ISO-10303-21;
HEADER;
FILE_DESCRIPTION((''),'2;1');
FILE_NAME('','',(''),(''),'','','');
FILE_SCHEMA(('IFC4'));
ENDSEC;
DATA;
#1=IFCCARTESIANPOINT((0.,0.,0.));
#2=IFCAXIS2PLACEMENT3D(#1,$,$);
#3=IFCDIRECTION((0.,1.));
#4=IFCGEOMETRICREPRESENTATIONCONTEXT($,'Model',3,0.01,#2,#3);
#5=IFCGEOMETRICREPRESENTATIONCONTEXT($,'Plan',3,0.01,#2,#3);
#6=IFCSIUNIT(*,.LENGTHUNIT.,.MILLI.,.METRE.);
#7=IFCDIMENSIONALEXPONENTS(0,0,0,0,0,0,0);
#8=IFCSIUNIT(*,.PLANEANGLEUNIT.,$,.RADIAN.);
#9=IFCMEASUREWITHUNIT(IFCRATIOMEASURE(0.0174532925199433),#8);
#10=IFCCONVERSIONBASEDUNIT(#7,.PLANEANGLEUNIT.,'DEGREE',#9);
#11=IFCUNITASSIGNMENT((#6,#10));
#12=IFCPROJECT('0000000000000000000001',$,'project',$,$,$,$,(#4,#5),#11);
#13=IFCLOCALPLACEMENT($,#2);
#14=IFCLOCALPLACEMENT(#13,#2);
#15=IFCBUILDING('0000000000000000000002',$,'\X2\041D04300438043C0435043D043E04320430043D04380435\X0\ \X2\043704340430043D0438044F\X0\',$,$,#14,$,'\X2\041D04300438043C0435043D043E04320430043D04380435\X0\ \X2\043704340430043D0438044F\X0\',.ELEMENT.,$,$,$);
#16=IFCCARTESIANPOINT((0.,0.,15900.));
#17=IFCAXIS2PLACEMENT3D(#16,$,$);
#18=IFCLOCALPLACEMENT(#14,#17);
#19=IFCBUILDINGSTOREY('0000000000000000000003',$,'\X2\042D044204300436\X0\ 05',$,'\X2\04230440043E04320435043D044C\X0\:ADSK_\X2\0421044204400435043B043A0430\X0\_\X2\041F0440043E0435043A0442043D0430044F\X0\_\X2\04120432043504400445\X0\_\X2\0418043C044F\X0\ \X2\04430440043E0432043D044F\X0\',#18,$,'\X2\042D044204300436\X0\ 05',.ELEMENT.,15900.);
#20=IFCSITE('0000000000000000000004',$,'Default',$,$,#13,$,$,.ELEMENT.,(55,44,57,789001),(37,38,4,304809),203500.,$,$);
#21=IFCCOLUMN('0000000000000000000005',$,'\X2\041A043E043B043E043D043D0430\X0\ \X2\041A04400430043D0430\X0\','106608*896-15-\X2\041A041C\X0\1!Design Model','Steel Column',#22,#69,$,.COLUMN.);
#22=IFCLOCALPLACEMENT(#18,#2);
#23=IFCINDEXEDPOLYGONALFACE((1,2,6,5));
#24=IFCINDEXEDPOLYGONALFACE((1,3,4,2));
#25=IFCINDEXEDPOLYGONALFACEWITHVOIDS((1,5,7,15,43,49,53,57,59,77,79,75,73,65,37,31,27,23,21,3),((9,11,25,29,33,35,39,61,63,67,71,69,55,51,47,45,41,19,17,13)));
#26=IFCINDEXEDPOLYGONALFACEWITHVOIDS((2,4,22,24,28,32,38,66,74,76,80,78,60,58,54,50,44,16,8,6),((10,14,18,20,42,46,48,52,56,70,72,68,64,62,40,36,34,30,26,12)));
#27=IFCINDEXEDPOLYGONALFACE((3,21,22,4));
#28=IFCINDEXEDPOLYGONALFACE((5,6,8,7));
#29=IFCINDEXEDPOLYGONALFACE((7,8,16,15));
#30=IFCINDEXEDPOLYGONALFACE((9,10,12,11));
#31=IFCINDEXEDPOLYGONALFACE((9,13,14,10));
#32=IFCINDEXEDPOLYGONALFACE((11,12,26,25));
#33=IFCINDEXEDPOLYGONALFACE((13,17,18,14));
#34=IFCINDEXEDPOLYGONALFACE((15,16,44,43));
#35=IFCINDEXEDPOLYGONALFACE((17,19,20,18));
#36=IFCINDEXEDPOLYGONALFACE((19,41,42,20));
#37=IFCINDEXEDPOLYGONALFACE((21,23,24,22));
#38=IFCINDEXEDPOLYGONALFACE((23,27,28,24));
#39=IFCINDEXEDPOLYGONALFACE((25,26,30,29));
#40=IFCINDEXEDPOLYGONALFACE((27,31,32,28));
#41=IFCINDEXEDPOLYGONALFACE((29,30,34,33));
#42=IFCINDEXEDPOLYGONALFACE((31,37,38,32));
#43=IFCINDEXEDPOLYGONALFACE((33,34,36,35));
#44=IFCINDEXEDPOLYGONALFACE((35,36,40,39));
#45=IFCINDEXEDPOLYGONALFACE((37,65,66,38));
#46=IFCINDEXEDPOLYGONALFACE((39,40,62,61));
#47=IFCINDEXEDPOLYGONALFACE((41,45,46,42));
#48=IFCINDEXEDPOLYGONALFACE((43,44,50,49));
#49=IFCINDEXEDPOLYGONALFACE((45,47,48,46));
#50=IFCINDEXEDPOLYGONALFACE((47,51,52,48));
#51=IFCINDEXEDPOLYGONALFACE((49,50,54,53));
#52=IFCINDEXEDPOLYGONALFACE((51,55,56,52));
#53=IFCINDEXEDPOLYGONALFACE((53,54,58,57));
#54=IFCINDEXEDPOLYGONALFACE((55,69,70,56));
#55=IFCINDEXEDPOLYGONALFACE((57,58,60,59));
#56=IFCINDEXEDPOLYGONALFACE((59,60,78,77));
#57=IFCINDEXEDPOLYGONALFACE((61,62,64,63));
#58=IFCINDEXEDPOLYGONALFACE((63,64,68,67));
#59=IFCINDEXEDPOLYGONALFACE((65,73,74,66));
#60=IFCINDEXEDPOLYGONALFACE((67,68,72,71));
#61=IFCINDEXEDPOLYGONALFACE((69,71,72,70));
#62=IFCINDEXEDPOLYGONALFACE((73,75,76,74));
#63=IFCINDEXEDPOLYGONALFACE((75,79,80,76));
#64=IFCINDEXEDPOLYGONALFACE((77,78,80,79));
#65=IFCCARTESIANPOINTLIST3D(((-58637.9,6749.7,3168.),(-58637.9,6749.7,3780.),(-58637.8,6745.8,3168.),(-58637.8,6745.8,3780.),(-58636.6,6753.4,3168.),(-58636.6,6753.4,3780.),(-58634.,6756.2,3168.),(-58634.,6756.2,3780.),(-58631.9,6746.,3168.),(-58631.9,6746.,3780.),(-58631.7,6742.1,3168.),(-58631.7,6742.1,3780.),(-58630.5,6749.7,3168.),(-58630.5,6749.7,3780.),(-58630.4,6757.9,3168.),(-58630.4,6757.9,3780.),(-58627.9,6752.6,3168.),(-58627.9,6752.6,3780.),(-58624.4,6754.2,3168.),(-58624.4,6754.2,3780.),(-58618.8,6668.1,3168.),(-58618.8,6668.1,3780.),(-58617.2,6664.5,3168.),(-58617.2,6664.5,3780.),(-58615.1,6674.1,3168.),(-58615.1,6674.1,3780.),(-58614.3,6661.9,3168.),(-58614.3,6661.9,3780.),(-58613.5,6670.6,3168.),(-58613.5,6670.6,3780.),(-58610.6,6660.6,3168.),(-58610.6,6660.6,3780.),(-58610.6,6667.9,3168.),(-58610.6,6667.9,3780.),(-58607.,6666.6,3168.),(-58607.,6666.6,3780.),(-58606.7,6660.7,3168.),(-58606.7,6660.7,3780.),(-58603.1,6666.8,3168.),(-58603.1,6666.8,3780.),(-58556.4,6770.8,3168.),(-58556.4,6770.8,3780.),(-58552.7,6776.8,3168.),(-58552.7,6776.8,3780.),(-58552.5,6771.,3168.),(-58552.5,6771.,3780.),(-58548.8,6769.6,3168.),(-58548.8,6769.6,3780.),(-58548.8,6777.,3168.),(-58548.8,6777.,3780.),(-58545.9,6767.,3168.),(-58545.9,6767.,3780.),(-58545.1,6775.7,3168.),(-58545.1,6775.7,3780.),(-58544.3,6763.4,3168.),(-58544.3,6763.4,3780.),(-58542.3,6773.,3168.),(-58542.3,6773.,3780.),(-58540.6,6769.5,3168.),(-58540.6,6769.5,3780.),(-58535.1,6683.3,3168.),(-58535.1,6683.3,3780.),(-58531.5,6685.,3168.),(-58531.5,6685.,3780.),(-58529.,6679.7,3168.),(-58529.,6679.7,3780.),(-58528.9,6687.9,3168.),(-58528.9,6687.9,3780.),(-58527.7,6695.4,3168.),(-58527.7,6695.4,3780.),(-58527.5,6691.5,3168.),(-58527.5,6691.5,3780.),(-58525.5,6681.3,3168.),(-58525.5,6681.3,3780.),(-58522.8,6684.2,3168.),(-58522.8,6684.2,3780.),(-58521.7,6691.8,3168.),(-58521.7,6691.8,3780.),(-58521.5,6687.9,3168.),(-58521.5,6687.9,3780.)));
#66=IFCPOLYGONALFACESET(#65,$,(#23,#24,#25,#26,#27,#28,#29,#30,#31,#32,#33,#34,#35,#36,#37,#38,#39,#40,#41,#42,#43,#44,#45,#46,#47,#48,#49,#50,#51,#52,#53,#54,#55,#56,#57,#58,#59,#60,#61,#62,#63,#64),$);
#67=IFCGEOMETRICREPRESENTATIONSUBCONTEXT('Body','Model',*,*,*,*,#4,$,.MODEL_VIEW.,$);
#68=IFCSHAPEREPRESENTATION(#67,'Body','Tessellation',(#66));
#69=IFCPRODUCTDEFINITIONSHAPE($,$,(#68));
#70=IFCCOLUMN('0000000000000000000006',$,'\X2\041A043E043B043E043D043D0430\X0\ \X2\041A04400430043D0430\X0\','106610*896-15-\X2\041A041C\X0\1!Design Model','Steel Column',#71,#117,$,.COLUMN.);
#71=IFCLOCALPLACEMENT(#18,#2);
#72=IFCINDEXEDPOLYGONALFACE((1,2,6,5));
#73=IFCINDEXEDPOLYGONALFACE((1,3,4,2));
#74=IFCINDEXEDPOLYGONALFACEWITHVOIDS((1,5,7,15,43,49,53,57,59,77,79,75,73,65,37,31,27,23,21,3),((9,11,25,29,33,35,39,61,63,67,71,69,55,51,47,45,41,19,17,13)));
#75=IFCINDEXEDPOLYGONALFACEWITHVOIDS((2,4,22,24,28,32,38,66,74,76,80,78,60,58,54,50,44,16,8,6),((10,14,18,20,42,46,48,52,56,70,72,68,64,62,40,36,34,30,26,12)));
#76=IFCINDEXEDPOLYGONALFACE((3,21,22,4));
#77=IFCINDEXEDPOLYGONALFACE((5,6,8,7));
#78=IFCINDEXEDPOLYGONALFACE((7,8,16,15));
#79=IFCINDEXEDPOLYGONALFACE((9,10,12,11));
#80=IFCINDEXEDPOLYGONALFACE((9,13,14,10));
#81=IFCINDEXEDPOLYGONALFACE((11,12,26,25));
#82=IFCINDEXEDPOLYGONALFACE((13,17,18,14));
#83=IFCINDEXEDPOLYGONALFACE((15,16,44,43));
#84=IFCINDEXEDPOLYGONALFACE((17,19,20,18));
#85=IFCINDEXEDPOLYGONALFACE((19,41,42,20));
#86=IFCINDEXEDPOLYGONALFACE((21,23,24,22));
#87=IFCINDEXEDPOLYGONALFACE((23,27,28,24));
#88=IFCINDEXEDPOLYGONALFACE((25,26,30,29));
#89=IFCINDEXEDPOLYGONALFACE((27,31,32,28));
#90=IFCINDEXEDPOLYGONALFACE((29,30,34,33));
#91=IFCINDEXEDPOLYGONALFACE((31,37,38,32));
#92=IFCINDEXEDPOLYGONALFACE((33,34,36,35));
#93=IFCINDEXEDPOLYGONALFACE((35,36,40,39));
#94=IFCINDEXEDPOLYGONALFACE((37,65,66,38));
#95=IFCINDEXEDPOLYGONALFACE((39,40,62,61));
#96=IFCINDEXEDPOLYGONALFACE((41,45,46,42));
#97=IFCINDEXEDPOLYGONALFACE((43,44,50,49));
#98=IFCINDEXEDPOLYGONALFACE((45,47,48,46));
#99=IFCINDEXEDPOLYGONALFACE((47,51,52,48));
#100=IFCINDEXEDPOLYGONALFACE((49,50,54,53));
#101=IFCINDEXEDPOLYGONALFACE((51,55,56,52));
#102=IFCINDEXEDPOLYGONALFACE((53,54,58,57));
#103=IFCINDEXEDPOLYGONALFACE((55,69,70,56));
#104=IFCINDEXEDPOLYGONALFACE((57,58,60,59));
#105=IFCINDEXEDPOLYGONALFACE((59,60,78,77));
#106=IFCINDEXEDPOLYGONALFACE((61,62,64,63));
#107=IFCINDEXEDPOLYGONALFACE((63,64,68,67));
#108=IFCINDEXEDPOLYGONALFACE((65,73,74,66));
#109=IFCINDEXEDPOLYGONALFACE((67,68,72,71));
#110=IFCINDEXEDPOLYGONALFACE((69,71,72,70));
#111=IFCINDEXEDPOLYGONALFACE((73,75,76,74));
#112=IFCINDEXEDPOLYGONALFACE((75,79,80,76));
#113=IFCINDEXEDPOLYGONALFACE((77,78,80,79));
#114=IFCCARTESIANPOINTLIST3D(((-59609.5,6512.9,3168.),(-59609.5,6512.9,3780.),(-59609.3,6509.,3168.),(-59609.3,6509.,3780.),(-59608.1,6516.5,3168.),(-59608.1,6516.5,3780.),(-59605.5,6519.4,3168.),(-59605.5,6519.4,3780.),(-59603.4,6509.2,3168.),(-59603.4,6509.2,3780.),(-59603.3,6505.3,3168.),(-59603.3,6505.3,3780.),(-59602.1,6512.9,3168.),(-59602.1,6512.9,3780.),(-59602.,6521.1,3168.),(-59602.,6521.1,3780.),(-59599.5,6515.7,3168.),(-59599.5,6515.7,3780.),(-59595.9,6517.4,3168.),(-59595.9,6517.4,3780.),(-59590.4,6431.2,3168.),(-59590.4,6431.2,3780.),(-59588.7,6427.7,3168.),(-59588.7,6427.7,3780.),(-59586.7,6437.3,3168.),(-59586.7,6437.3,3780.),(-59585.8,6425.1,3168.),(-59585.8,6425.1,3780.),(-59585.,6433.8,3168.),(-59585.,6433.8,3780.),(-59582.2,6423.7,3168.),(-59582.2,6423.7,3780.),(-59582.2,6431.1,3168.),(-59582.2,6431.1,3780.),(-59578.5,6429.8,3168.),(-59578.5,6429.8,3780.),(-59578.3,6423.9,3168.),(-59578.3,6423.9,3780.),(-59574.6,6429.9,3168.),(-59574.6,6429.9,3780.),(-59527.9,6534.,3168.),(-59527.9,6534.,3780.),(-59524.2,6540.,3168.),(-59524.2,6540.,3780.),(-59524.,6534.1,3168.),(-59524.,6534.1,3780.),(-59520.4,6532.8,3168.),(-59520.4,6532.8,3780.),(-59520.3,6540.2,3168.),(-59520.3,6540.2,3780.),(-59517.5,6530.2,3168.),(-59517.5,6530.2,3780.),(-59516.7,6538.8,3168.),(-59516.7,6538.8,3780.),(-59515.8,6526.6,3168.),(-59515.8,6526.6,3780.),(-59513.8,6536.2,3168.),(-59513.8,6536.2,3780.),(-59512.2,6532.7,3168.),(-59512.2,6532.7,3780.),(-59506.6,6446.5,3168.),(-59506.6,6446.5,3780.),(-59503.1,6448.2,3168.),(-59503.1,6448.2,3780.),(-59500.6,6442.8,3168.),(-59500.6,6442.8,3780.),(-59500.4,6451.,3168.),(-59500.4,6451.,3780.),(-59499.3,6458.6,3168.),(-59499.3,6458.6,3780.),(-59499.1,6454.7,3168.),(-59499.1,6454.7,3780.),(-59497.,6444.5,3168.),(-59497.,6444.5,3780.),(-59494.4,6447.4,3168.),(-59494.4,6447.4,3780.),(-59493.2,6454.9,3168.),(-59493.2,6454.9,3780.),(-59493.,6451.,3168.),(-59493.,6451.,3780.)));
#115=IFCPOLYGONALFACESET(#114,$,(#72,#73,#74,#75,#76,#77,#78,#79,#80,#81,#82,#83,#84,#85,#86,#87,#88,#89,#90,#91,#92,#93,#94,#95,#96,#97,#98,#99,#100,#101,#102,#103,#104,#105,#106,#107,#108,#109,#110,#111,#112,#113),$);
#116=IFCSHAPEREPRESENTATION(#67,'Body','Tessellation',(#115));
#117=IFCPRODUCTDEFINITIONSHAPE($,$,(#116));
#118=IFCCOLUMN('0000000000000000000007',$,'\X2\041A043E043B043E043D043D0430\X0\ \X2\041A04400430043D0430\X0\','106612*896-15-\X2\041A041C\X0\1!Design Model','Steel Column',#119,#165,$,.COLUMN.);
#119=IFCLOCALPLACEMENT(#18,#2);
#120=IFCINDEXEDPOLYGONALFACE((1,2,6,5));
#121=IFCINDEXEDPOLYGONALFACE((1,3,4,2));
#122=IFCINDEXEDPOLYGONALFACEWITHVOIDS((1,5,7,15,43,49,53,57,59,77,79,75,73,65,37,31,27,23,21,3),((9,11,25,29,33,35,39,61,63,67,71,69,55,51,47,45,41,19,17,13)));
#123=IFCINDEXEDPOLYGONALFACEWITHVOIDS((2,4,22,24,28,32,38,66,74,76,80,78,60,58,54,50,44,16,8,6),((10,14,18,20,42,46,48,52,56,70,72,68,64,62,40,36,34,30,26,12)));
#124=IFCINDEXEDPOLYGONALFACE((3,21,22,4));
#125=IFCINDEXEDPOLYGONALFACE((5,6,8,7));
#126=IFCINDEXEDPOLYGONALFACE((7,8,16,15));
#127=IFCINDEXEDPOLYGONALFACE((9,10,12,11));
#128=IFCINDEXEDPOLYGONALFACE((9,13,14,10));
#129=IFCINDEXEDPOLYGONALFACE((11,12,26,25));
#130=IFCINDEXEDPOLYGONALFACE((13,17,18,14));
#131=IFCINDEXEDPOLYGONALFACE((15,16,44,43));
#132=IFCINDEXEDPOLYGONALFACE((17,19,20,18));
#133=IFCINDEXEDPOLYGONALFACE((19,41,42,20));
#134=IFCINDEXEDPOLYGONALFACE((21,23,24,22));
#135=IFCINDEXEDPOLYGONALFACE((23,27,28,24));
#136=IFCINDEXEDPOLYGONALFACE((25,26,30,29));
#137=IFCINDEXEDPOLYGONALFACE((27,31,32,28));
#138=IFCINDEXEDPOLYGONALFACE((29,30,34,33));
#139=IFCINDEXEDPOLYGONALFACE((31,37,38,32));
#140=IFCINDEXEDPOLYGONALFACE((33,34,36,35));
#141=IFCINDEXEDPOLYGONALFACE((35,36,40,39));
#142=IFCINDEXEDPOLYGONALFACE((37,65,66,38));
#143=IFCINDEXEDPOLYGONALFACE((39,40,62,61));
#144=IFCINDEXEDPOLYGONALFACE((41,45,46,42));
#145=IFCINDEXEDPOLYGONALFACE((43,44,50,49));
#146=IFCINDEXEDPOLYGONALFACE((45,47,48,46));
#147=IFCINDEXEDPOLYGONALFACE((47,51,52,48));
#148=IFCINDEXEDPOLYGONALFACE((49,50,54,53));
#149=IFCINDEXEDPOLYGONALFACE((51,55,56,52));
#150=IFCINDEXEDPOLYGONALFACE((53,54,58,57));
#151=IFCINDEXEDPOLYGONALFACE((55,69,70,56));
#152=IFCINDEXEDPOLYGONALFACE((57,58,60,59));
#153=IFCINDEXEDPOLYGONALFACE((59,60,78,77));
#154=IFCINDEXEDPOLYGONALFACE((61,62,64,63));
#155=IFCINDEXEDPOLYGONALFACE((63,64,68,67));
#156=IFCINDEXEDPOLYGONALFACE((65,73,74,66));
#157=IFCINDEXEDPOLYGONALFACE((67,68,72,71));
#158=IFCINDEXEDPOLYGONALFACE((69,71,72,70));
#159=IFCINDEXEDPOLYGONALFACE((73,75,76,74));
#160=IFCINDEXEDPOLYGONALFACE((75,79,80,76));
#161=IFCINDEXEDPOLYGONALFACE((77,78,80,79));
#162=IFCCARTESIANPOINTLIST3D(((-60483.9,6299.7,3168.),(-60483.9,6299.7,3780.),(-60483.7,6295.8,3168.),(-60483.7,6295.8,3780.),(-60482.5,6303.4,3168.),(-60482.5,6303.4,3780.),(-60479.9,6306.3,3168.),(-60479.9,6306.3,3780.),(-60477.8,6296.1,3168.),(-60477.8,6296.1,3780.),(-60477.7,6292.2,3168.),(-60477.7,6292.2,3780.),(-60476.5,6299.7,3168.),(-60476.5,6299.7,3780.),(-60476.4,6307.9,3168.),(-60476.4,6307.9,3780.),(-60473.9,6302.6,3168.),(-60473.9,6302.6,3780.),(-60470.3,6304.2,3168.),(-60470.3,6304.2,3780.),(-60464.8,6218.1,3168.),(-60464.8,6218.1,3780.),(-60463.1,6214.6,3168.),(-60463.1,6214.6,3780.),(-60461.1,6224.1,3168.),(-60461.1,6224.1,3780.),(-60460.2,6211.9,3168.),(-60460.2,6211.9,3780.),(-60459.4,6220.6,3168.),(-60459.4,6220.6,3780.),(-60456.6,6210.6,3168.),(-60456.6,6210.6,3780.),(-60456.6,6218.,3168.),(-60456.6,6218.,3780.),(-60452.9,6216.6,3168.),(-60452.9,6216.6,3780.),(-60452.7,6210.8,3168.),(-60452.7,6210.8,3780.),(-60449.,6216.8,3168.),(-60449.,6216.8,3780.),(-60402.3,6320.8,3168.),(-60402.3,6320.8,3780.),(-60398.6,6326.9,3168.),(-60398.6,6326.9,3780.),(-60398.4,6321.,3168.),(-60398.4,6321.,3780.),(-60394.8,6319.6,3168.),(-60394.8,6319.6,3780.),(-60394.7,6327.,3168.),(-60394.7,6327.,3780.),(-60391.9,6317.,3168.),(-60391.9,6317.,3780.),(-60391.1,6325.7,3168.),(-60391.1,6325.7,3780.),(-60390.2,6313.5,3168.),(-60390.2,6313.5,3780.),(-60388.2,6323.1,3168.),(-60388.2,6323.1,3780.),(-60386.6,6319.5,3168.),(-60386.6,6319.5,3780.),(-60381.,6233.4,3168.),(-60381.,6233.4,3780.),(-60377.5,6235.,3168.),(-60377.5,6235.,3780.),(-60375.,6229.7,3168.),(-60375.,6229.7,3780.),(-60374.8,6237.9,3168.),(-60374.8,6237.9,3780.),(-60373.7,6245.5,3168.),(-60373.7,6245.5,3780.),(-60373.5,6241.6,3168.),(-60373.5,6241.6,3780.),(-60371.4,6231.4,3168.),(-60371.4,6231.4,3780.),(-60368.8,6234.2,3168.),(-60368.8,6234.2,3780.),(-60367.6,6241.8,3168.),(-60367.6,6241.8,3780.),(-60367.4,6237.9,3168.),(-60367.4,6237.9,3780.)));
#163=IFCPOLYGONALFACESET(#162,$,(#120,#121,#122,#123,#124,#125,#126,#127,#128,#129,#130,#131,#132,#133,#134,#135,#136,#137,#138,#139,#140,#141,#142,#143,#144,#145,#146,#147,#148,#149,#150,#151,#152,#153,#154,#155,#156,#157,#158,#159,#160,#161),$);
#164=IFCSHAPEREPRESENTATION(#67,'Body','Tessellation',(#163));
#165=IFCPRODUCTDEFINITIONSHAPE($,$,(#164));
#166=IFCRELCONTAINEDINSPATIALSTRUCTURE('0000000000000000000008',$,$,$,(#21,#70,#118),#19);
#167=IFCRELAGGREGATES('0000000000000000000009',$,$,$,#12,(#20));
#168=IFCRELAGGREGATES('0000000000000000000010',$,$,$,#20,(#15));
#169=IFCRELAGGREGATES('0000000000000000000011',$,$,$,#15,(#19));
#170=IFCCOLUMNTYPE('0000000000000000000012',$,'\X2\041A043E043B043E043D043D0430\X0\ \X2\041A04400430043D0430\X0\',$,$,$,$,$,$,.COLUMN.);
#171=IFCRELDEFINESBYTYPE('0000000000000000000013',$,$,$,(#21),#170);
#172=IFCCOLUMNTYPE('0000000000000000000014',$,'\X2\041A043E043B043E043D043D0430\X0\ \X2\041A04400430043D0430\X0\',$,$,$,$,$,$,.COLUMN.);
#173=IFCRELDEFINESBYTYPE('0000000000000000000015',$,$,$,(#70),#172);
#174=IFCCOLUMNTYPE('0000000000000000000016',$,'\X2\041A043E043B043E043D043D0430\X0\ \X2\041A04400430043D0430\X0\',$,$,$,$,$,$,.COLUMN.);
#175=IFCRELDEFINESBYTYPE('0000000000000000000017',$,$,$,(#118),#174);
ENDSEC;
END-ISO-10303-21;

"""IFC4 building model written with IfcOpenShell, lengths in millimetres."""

from ifc_helpers import new_model, entity, si_unit, converted_unit, direction, frame, origin, place, context, subcontext, project, spatial, indexed_curve, outline, extrude, type_object, element, save


model = new_model("IFC4")

# Units and contexts
model_context = context("Model", 3, precision=0.01, world=origin(), true_north=direction((0.0, 1.0)))
plan_context = context("Plan", 3, precision=0.01, world=origin(), true_north=direction((0.0, 1.0)))
body_context = subcontext(model_context, "Body", "Model", "MODEL_VIEW")
ifc_project = project(units=[si_unit("LENGTHUNIT", "METRE", prefix="MILLI"), converted_unit("PLANEANGLEUNIT", "DEGREE", entity("IfcRatioMeasure", 0.0174532925199433), si_unit("PLANEANGLEUNIT", "RADIAN"), dimensions=[0, 0, 0, 0, 0, 0, 0])], contexts=[model_context, plan_context])

# Site, building, storey
site_placement = place(None, origin())
site = spatial("IfcSite", under=ifc_project, at=site_placement, Name="Default", CompositionType="ELEMENT", RefLatitude=(55, 44, 57, 789001), RefLongitude=(37, 38, 4, 304809), RefElevation=203500.0)
building_placement = place(site_placement, origin())
building = spatial("IfcBuilding", under=site, at=building_placement, Name="Наименование здания", LongName="Наименование здания", CompositionType="ELEMENT")
storey_placement = place(building_placement, frame((0.0, 0.0, 15900.0)))
storey = spatial("IfcBuildingStorey", under=building, at=storey_placement, Name="Этаж 05", ObjectType="Уровень:ADSK_Стрелка_Проектная_Вверх_Имя уровня", LongName="Этаж 05", CompositionType="ELEMENT", Elevation=15900.0)

# Columns
column_type_1 = type_object("IfcColumnType", Name="Колонна Крана", PredefinedType="COLUMN")
column_1_placement = place(storey_placement, origin())
element("IfcColumn", 1, at=column_1_placement, inside=storey, type_object=column_type_1, Name="Колонна Крана", Description="106608*896-15-КМ1!Design Model", ObjectType="Steel Column", PredefinedType="COLUMN", context=body_context, shape_type="SweptSolid", body=[
    extrude(outline(indexed_curve([(29.5, -56.8), (33.4, -56.8), (37.0, -55.3), (39.7, -52.6), (41.2, -49.0), (56.8, 29.5), (56.8, 33.4), (55.3, 37.0), (52.6, 39.7), (49.0, 41.2), (-29.5, 56.8), (-33.4, 56.8), (-37.0, 55.3), (-39.7, 52.6), (-41.2, 49.0), (-56.8, -29.5), (-56.8, -33.4), (-55.3, -37.0), (-52.6, -39.7), (-49.0, -41.2), (29.5, -56.8)], self_intersect=False), holes=[indexed_curve([(-43.1, -37.3), (-46.7, -35.8), (-49.5, -33.1), (-51.0, -29.5), (-51.0, -25.5), (-37.3, 43.1), (-35.8, 46.7), (-33.1, 49.5), (-29.5, 51.0), (-25.5, 51.0), (43.1, 37.3), (46.7, 35.8), (49.5, 33.1), (51.0, 29.5), (51.0, 25.5), (37.3, -43.1), (35.8, -46.7), (33.1, -49.5), (29.5, -51.0), (25.5, -51.0), (-43.1, -37.3)], self_intersect=False)]), frame((-58579.7, 6718.8, 3168.0), z_axis=(0.0, 0.0, 1.0), x_axis=(0.906681, 0.421816, 0.0)), (0.0, 0.0, 1.0), 612.0),
])
column_type_2 = type_object("IfcColumnType", Name="Колонна Крана", PredefinedType="COLUMN")
column_2_placement = place(storey_placement, origin())
element("IfcColumn", 2, at=column_2_placement, inside=storey, type_object=column_type_2, Name="Колонна Крана", Description="106610*896-15-КМ1!Design Model", ObjectType="Steel Column", PredefinedType="COLUMN", context=body_context, shape_type="SweptSolid", body=[
    extrude(outline(indexed_curve([(29.5, -56.8), (33.4, -56.8), (37.0, -55.3), (39.7, -52.6), (41.2, -49.0), (56.8, 29.5), (56.8, 33.4), (55.3, 37.0), (52.6, 39.7), (49.0, 41.2), (-29.5, 56.8), (-33.4, 56.8), (-37.0, 55.3), (-39.7, 52.6), (-41.2, 49.0), (-56.8, -29.5), (-56.8, -33.4), (-55.3, -37.0), (-52.6, -39.7), (-49.0, -41.2), (29.5, -56.8)], self_intersect=False), holes=[indexed_curve([(-43.1, -37.3), (-46.7, -35.8), (-49.5, -33.1), (-51.0, -29.5), (-51.0, -25.5), (-37.3, 43.1), (-35.8, 46.7), (-33.1, 49.5), (-29.5, 51.0), (-25.5, 51.0), (43.1, 37.3), (46.7, 35.8), (49.5, 33.1), (51.0, 29.5), (51.0, 25.5), (37.3, -43.1), (35.8, -46.7), (33.1, -49.5), (29.5, -51.0), (25.5, -51.0), (-43.1, -37.3)], self_intersect=False)]), frame((-59551.3, 6482.0, 3168.0), z_axis=(0.0, 0.0, 1.0), x_axis=(0.906681, 0.421816, 0.0)), (0.0, 0.0, 1.0), 612.0),
])
column_type_3 = type_object("IfcColumnType", Name="Колонна Крана", PredefinedType="COLUMN")
column_3_placement = place(storey_placement, origin())
element("IfcColumn", 3, at=column_3_placement, inside=storey, type_object=column_type_3, Name="Колонна Крана", Description="106612*896-15-КМ1!Design Model", ObjectType="Steel Column", PredefinedType="COLUMN", context=body_context, shape_type="SweptSolid", body=[
    extrude(outline(indexed_curve([(29.5, -56.8), (33.4, -56.8), (37.0, -55.3), (39.7, -52.6), (41.2, -49.0), (56.8, 29.5), (56.8, 33.4), (55.3, 37.0), (52.6, 39.7), (49.0, 41.2), (-29.5, 56.8), (-33.4, 56.8), (-37.0, 55.3), (-39.7, 52.6), (-41.2, 49.0), (-56.8, -29.5), (-56.8, -33.4), (-55.3, -37.0), (-52.6, -39.7), (-49.0, -41.2), (29.5, -56.8)], self_intersect=False), holes=[indexed_curve([(-43.1, -37.3), (-46.7, -35.8), (-49.5, -33.1), (-51.0, -29.5), (-51.0, -25.5), (-37.3, 43.1), (-35.8, 46.7), (-33.1, 49.5), (-29.5, 51.0), (-25.5, 51.0), (43.1, 37.3), (46.7, 35.8), (49.5, 33.1), (51.0, 29.5), (51.0, 25.5), (37.3, -43.1), (35.8, -46.7), (33.1, -49.5), (29.5, -51.0), (25.5, -51.0), (-43.1, -37.3)], self_intersect=False)]), frame((-60425.7, 6268.8, 3168.0), z_axis=(0.0, 0.0, 1.0), x_axis=(0.906681, 0.421816, 0.0)), (0.0, 0.0, 1.0), 612.0),
])

save(model, "model.ifc")
